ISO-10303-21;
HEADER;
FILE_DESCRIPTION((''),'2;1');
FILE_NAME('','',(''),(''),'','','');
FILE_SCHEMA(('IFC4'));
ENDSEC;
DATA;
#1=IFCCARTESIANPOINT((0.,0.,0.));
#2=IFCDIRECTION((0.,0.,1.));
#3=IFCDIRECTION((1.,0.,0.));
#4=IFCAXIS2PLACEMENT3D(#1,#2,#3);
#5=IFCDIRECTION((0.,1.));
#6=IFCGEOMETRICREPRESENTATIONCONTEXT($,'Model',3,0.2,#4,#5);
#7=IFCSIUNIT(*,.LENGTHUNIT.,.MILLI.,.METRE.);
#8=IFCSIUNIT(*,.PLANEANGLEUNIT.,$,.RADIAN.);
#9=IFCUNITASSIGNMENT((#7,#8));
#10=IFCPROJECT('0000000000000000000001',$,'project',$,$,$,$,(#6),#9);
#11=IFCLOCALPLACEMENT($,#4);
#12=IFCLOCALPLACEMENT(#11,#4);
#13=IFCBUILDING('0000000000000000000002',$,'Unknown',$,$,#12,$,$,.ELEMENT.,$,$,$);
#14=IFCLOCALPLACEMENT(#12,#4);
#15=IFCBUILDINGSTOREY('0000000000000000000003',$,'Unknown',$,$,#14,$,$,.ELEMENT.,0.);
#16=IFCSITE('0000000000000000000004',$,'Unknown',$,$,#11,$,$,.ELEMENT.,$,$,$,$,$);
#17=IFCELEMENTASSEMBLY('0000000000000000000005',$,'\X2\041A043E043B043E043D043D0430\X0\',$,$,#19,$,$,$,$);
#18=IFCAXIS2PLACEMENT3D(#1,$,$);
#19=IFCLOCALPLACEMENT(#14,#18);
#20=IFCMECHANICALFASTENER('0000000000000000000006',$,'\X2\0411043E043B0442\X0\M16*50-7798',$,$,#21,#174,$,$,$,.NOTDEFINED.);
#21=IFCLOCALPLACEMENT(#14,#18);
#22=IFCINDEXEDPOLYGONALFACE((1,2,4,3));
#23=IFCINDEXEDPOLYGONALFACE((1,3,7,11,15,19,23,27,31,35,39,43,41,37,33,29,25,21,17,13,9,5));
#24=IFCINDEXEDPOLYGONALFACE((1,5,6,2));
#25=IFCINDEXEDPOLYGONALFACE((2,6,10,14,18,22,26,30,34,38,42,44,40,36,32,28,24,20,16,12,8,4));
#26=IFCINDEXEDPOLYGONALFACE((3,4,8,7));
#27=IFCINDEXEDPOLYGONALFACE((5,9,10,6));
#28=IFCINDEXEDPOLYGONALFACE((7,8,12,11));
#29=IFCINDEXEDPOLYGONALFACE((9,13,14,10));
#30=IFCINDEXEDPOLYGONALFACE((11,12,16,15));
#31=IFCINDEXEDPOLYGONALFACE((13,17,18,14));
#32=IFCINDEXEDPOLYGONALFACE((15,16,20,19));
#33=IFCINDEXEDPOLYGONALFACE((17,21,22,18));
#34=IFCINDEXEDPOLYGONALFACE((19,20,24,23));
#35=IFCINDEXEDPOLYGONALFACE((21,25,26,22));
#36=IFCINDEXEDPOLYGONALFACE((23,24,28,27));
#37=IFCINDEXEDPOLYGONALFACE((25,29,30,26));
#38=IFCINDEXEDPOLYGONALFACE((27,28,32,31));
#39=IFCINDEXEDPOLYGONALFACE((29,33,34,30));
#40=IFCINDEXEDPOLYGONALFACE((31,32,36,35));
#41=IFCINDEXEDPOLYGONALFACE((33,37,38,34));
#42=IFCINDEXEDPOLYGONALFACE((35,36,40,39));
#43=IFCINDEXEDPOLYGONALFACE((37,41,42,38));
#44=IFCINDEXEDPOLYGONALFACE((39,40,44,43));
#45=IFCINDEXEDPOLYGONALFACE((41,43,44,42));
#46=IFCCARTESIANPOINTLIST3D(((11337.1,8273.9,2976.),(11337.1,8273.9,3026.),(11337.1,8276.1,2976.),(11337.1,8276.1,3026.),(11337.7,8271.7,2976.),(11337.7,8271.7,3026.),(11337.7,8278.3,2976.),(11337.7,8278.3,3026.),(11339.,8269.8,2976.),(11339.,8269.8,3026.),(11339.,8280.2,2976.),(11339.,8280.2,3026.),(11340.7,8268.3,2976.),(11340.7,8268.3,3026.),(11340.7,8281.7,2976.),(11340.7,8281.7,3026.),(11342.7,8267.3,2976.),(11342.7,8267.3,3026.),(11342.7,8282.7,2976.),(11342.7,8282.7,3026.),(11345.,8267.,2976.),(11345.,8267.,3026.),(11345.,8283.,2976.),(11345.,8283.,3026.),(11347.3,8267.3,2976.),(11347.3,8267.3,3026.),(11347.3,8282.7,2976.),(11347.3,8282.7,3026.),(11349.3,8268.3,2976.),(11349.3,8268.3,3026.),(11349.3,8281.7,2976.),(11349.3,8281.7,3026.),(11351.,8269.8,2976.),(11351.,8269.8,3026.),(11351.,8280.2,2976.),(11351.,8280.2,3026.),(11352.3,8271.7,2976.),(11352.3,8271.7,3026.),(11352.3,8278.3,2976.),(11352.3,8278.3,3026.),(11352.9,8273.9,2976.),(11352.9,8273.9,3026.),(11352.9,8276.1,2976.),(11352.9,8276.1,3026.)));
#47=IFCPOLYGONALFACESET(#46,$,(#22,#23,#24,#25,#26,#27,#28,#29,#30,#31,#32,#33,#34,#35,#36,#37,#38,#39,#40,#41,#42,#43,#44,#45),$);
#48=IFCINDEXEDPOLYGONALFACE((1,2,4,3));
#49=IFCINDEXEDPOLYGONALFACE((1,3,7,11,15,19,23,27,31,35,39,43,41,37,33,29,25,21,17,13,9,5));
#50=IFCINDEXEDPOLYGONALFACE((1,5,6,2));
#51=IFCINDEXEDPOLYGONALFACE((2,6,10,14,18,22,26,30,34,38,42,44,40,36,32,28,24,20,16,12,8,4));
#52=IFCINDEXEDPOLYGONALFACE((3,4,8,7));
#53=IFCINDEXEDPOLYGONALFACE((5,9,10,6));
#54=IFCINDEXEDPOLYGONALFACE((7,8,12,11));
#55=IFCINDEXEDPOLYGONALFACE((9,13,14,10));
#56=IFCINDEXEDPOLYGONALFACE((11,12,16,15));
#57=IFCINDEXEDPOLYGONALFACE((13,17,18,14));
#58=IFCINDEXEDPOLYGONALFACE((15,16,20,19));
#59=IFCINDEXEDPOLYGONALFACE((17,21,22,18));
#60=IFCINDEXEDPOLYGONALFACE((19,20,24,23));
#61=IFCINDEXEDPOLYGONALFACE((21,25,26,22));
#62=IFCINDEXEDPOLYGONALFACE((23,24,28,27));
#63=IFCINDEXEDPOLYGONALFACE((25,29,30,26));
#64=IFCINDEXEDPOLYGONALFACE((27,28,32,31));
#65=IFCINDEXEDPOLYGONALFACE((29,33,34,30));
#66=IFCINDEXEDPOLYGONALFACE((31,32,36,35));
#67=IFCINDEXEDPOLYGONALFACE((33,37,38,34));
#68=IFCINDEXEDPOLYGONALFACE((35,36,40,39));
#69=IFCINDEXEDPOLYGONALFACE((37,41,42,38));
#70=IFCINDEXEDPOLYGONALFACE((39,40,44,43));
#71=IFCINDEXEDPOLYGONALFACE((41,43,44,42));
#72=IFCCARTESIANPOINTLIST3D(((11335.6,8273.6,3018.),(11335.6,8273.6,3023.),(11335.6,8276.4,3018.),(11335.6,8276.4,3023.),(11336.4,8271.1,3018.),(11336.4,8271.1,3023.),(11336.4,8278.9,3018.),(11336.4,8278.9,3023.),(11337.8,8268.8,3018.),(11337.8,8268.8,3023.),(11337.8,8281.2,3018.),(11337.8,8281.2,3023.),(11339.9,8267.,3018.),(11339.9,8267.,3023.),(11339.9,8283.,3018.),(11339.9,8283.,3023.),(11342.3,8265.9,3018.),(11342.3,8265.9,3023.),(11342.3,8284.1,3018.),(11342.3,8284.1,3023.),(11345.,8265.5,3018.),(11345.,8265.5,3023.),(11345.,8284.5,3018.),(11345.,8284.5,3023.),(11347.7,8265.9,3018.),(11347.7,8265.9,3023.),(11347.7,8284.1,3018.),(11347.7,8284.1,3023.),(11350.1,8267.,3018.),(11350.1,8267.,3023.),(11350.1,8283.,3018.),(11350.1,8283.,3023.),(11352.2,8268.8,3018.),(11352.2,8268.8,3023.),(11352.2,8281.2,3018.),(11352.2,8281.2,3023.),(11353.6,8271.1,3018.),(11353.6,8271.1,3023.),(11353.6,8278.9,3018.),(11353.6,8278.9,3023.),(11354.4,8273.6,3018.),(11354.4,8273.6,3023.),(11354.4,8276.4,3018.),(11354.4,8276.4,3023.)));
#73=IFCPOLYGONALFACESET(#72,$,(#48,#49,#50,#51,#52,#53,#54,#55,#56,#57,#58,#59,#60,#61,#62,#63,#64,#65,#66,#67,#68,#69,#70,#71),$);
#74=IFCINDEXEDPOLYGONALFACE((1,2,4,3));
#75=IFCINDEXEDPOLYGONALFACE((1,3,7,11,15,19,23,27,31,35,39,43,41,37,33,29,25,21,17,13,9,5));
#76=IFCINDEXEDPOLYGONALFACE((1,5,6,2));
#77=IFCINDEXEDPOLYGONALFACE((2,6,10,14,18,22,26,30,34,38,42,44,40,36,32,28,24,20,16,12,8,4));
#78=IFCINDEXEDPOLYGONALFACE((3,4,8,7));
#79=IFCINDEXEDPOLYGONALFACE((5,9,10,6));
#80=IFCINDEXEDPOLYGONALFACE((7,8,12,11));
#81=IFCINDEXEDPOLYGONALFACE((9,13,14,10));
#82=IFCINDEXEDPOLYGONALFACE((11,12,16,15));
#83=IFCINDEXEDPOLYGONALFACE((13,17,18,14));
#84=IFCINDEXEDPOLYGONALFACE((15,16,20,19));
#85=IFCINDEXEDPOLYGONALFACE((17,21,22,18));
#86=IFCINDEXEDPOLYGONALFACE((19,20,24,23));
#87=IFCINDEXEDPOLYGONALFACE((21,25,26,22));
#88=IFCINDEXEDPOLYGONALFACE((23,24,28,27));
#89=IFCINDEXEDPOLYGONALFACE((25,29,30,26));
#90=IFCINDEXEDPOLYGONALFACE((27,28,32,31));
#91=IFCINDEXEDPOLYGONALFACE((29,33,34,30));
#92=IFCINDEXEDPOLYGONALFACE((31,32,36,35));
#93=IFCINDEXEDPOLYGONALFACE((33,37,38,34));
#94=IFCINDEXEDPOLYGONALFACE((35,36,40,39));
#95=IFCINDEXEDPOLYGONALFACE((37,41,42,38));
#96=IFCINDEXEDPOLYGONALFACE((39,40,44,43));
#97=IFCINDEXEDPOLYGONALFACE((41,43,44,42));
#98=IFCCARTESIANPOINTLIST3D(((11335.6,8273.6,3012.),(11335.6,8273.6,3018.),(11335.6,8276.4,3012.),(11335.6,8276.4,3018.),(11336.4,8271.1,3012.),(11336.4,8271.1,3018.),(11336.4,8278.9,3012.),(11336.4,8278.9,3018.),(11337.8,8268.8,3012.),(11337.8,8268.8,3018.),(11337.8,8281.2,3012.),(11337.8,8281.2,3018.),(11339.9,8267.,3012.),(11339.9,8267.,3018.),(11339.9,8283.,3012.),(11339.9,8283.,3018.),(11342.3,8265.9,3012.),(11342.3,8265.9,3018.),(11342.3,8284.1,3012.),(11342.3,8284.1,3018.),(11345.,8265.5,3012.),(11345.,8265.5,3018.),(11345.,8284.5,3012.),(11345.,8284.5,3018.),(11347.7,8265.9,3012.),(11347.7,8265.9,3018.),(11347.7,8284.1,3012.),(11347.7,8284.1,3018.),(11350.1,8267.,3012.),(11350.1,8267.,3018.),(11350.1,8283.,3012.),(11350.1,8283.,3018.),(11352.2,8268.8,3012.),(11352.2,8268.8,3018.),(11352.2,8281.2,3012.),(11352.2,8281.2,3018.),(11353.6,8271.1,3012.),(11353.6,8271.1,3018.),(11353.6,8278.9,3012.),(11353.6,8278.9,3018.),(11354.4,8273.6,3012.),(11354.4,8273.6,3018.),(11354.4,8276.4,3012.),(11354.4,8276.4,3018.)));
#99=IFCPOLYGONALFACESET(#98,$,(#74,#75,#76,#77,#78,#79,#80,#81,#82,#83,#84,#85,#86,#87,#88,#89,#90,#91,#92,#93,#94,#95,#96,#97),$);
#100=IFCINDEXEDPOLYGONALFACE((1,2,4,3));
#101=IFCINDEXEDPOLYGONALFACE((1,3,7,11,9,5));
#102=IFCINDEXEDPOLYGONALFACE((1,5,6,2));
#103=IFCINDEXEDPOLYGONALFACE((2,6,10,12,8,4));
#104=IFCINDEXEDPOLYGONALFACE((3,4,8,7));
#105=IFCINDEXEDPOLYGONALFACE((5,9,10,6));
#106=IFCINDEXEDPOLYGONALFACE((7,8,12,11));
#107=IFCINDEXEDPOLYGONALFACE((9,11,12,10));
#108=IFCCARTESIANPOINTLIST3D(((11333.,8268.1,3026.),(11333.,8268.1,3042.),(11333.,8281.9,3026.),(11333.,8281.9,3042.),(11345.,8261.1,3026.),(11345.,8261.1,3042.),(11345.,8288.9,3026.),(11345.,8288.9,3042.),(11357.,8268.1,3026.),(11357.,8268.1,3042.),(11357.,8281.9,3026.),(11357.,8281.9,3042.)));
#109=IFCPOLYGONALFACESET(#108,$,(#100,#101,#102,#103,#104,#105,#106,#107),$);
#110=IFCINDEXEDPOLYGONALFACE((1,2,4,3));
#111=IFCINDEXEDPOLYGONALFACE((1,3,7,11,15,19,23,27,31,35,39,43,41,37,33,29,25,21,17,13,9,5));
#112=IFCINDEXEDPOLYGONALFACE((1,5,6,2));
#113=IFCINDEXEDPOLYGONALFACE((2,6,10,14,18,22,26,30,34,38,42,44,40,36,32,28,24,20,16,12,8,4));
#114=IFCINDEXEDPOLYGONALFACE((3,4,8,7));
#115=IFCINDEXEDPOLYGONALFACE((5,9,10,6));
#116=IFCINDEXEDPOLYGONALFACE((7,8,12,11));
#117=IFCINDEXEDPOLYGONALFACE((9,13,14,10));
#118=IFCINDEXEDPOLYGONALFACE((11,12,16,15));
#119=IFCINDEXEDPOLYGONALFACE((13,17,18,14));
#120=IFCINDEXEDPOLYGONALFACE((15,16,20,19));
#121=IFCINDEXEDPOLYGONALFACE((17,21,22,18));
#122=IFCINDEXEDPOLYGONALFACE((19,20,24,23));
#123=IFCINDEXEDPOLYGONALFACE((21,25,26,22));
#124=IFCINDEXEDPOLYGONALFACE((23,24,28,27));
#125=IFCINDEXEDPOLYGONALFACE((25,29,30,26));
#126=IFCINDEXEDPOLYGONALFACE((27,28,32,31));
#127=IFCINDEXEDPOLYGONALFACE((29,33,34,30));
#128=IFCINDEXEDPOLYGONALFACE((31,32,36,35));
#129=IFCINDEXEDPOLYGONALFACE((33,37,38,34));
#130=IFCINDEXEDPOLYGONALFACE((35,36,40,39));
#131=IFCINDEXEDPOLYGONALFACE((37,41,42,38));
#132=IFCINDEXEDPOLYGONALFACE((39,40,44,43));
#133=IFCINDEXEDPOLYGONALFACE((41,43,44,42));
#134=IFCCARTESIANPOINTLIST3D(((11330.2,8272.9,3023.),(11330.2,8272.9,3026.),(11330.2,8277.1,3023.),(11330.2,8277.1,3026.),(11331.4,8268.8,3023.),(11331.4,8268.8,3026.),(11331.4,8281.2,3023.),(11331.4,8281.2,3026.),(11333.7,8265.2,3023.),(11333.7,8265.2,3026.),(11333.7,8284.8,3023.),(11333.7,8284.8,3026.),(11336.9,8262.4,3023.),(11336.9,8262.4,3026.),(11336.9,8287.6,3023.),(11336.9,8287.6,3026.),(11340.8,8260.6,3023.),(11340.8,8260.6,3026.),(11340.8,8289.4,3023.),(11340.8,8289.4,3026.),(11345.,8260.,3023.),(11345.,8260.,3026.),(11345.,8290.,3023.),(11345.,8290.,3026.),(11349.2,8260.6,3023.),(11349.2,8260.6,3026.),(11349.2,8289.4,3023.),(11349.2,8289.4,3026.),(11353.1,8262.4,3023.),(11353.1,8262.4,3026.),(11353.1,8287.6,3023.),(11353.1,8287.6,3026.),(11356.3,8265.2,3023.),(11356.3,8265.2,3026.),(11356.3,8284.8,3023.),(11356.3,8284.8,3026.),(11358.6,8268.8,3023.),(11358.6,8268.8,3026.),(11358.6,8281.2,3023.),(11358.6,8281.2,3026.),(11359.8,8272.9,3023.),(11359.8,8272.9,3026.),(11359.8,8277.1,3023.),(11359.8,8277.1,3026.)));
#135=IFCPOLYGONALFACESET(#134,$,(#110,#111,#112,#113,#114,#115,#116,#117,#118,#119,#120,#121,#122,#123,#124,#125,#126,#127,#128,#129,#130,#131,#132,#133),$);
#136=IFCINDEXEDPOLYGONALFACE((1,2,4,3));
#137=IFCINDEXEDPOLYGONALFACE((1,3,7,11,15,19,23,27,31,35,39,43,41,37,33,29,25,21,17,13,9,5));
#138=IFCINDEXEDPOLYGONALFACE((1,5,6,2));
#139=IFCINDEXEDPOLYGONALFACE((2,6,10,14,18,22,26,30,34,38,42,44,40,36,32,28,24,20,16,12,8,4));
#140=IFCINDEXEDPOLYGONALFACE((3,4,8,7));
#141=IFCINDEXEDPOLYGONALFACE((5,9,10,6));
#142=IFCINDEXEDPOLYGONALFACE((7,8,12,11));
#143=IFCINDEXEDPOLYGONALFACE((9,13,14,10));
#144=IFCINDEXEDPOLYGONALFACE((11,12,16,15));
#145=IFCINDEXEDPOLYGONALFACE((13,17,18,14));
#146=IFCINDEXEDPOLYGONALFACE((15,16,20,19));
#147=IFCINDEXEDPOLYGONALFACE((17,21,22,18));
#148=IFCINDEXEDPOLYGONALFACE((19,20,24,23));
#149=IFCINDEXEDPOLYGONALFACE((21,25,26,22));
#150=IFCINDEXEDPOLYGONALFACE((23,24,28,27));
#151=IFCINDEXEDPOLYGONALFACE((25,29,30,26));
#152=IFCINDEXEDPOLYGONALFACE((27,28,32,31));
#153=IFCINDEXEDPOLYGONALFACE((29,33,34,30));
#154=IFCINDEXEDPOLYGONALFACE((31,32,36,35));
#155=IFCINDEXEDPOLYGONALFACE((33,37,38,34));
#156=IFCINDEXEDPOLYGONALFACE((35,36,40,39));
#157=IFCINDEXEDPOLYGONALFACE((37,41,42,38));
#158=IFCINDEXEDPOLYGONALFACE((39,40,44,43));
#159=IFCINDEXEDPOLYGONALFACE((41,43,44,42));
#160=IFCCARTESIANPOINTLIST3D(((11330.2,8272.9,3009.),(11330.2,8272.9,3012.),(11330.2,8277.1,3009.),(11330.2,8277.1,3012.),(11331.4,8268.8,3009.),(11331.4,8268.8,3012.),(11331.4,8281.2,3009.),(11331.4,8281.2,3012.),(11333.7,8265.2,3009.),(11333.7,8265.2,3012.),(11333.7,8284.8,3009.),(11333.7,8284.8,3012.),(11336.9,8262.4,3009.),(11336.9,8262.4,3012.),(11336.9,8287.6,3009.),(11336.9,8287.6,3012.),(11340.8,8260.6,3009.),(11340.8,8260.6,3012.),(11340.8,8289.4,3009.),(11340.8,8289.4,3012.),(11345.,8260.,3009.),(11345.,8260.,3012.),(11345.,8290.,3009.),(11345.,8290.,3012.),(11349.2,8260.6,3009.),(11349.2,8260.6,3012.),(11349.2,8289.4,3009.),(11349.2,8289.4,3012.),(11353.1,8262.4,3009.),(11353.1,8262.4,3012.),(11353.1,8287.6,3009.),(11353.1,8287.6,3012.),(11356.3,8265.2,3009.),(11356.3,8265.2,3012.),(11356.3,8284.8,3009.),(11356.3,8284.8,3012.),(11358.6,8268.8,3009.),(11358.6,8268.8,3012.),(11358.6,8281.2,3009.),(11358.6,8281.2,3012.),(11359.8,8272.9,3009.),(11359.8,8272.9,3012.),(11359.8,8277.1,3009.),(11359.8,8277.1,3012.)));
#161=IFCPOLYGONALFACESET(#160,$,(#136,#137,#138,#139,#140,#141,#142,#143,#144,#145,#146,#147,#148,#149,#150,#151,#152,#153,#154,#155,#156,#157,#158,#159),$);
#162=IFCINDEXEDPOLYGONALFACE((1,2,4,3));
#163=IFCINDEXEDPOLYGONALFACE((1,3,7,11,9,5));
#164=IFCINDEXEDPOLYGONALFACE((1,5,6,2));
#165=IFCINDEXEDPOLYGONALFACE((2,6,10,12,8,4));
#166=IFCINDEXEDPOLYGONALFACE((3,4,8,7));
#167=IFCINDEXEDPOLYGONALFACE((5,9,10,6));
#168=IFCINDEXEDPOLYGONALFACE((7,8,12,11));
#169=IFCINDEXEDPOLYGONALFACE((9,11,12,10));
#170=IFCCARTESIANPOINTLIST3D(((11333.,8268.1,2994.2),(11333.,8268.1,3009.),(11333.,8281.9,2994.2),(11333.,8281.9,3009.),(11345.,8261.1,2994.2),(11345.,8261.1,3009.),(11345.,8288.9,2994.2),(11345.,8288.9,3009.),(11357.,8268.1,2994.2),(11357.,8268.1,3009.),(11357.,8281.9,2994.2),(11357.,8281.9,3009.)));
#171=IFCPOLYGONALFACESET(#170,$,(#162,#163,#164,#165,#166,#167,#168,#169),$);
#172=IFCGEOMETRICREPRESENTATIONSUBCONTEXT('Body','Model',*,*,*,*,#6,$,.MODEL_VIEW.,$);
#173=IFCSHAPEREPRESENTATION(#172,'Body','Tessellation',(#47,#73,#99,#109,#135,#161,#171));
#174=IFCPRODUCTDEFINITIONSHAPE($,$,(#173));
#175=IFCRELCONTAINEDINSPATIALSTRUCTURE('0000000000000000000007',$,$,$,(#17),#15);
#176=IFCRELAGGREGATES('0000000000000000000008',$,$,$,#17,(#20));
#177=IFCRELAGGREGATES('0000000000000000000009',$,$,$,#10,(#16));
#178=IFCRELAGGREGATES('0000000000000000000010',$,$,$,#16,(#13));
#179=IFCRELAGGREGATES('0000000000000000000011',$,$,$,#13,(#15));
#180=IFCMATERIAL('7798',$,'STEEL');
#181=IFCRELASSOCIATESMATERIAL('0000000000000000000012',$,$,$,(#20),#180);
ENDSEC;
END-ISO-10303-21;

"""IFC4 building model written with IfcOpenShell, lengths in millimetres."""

from ifc_helpers import new_model, si_unit, direction, frame, origin_with_axes, place, context, subcontext, project, spatial, line, arc, indexed_curve, outline, extrude, source, transform, mapped, material, element, aggregate, save


model = new_model("IFC4")

# Units and contexts
model_context = context("Model", 3, precision=0.2, world=origin_with_axes(), true_north=direction((0.0, 1.0)))
body_context = subcontext(model_context, "Body", "Model", "MODEL_VIEW")
ifc_project = project(units=[si_unit("LENGTHUNIT", "METRE", prefix="MILLI"), si_unit("PLANEANGLEUNIT", "RADIAN")], contexts=[model_context])

# Site, building, storey
site_placement = place(None, origin_with_axes())
site = spatial("IfcSite", under=ifc_project, at=site_placement, Name="Unknown", CompositionType="ELEMENT")
building_placement = place(site_placement, origin_with_axes())
building = spatial("IfcBuilding", under=site, at=building_placement, Name="Unknown", CompositionType="ELEMENT")
storey_placement = place(building_placement, origin_with_axes())
storey = spatial("IfcBuildingStorey", under=building, at=storey_placement, Name="Unknown", CompositionType="ELEMENT", Elevation=0.0)

# Element assembly
assembly_1_placement = place(storey_placement, frame((11400.0, 8400.0, -40.0), z_axis=(-1.0, 0.0, 0.0), x_axis=(0.0, 0.0, 1.0)))
assembly_1 = element("IfcElementAssembly", 1, at=assembly_1_placement, inside=storey, Name="Колонна")

# Mechanical fastener
ifc_material_1 = material(Name="7798", Category="STEEL")
shared_shape_1 = source(origin_with_axes(), body_context, "Body", "SweptSolid", [
    extrude(outline(indexed_curve([(8.0, 0.0), (0.0, 8.0), (-8.0, 0.0), (0.0, -8.0)], segments=[arc(1, 2, 3), arc(3, 4, 1)])), frame((0.0, 0.0, 8.0), z_axis=(0.0, 0.0, -1.0), x_axis=(0.0, 1.0, 0.0)), (0.0, 0.0, 1.0), 50.0),
    extrude(outline(indexed_curve([(9.5, 0.0), (0.0, 9.5), (-9.5, 0.0), (0.0, -9.5)], segments=[arc(1, 2, 3), arc(3, 4, 1)])), frame((0.0, 0.0, 5.0), z_axis=(0.0, 0.0, -1.0), x_axis=(0.0, 1.0, 0.0)), (0.0, 0.0, 1.0), 5.0),
    extrude(outline(indexed_curve([(9.5, 0.0), (0.0, 9.5), (-9.5, 0.0), (0.0, -9.5)], segments=[arc(1, 2, 3), arc(3, 4, 1)])), frame((0.0, 0.0, 0.0), z_axis=(0.0, 0.0, -1.0), x_axis=(0.0, 1.0, 0.0)), (0.0, 0.0, 1.0), 6.0),
    extrude(outline(indexed_curve([(13.9, 0.0), (6.9, 12.0), (-6.9, 12.0), (-13.9, 0.0), (-6.9, -12.0), (6.9, -12.0)], segments=[line(1, 2, 3, 4, 5, 6, 1)])), frame((0.0, 0.0, 24.0), z_axis=(0.0, 0.0, -1.0), x_axis=(0.0, 1.0, 0.0)), (0.0, 0.0, 1.0), 16.0),
    extrude(outline(indexed_curve([(15.0, 0.0), (0.0, 15.0), (-15.0, 0.0), (0.0, -15.0)], segments=[arc(1, 2, 3), arc(3, 4, 1)])), frame((0.0, 0.0, 8.0), z_axis=(0.0, 0.0, -1.0), x_axis=(0.0, 1.0, 0.0)), (0.0, 0.0, 1.0), 3.0),
    extrude(outline(indexed_curve([(15.0, 0.0), (0.0, 15.0), (-15.0, 0.0), (0.0, -15.0)], segments=[arc(1, 2, 3), arc(3, 4, 1)])), frame((0.0, 0.0, -6.0), z_axis=(0.0, 0.0, -1.0), x_axis=(0.0, 1.0, 0.0)), (0.0, 0.0, 1.0), 3.0),
    extrude(outline(indexed_curve([(13.9, 0.0), (6.9, 12.0), (-6.9, 12.0), (-13.9, 0.0), (-6.9, -12.0), (6.9, -12.0)], segments=[line(1, 2, 3, 4, 5, 6, 1)])), frame((0.0, 0.0, -9.0), z_axis=(0.0, 0.0, -1.0), x_axis=(0.0, 1.0, 0.0)), (0.0, 0.0, 1.0), 14.8),
])
mechanical_fastener_1_placement = place(assembly_1_placement, frame((3058.0, -125.0, 55.0), z_axis=(1.0, 0.0, 0.0), x_axis=(0.0, 0.0, -1.0)))
mechanical_fastener_1 = element("IfcMechanicalFastener", 2, at=mechanical_fastener_1_placement, material=ifc_material_1, Name="БолтM16*50-7798", PredefinedType="NOTDEFINED", context=body_context, shape_type="MappedRepresentation", body=[
    mapped(shared_shape_1, transform((0.0, 0.0, 0.0))),
])
aggregate(assembly_1, [mechanical_fastener_1])

save(model, "model.ifc")
